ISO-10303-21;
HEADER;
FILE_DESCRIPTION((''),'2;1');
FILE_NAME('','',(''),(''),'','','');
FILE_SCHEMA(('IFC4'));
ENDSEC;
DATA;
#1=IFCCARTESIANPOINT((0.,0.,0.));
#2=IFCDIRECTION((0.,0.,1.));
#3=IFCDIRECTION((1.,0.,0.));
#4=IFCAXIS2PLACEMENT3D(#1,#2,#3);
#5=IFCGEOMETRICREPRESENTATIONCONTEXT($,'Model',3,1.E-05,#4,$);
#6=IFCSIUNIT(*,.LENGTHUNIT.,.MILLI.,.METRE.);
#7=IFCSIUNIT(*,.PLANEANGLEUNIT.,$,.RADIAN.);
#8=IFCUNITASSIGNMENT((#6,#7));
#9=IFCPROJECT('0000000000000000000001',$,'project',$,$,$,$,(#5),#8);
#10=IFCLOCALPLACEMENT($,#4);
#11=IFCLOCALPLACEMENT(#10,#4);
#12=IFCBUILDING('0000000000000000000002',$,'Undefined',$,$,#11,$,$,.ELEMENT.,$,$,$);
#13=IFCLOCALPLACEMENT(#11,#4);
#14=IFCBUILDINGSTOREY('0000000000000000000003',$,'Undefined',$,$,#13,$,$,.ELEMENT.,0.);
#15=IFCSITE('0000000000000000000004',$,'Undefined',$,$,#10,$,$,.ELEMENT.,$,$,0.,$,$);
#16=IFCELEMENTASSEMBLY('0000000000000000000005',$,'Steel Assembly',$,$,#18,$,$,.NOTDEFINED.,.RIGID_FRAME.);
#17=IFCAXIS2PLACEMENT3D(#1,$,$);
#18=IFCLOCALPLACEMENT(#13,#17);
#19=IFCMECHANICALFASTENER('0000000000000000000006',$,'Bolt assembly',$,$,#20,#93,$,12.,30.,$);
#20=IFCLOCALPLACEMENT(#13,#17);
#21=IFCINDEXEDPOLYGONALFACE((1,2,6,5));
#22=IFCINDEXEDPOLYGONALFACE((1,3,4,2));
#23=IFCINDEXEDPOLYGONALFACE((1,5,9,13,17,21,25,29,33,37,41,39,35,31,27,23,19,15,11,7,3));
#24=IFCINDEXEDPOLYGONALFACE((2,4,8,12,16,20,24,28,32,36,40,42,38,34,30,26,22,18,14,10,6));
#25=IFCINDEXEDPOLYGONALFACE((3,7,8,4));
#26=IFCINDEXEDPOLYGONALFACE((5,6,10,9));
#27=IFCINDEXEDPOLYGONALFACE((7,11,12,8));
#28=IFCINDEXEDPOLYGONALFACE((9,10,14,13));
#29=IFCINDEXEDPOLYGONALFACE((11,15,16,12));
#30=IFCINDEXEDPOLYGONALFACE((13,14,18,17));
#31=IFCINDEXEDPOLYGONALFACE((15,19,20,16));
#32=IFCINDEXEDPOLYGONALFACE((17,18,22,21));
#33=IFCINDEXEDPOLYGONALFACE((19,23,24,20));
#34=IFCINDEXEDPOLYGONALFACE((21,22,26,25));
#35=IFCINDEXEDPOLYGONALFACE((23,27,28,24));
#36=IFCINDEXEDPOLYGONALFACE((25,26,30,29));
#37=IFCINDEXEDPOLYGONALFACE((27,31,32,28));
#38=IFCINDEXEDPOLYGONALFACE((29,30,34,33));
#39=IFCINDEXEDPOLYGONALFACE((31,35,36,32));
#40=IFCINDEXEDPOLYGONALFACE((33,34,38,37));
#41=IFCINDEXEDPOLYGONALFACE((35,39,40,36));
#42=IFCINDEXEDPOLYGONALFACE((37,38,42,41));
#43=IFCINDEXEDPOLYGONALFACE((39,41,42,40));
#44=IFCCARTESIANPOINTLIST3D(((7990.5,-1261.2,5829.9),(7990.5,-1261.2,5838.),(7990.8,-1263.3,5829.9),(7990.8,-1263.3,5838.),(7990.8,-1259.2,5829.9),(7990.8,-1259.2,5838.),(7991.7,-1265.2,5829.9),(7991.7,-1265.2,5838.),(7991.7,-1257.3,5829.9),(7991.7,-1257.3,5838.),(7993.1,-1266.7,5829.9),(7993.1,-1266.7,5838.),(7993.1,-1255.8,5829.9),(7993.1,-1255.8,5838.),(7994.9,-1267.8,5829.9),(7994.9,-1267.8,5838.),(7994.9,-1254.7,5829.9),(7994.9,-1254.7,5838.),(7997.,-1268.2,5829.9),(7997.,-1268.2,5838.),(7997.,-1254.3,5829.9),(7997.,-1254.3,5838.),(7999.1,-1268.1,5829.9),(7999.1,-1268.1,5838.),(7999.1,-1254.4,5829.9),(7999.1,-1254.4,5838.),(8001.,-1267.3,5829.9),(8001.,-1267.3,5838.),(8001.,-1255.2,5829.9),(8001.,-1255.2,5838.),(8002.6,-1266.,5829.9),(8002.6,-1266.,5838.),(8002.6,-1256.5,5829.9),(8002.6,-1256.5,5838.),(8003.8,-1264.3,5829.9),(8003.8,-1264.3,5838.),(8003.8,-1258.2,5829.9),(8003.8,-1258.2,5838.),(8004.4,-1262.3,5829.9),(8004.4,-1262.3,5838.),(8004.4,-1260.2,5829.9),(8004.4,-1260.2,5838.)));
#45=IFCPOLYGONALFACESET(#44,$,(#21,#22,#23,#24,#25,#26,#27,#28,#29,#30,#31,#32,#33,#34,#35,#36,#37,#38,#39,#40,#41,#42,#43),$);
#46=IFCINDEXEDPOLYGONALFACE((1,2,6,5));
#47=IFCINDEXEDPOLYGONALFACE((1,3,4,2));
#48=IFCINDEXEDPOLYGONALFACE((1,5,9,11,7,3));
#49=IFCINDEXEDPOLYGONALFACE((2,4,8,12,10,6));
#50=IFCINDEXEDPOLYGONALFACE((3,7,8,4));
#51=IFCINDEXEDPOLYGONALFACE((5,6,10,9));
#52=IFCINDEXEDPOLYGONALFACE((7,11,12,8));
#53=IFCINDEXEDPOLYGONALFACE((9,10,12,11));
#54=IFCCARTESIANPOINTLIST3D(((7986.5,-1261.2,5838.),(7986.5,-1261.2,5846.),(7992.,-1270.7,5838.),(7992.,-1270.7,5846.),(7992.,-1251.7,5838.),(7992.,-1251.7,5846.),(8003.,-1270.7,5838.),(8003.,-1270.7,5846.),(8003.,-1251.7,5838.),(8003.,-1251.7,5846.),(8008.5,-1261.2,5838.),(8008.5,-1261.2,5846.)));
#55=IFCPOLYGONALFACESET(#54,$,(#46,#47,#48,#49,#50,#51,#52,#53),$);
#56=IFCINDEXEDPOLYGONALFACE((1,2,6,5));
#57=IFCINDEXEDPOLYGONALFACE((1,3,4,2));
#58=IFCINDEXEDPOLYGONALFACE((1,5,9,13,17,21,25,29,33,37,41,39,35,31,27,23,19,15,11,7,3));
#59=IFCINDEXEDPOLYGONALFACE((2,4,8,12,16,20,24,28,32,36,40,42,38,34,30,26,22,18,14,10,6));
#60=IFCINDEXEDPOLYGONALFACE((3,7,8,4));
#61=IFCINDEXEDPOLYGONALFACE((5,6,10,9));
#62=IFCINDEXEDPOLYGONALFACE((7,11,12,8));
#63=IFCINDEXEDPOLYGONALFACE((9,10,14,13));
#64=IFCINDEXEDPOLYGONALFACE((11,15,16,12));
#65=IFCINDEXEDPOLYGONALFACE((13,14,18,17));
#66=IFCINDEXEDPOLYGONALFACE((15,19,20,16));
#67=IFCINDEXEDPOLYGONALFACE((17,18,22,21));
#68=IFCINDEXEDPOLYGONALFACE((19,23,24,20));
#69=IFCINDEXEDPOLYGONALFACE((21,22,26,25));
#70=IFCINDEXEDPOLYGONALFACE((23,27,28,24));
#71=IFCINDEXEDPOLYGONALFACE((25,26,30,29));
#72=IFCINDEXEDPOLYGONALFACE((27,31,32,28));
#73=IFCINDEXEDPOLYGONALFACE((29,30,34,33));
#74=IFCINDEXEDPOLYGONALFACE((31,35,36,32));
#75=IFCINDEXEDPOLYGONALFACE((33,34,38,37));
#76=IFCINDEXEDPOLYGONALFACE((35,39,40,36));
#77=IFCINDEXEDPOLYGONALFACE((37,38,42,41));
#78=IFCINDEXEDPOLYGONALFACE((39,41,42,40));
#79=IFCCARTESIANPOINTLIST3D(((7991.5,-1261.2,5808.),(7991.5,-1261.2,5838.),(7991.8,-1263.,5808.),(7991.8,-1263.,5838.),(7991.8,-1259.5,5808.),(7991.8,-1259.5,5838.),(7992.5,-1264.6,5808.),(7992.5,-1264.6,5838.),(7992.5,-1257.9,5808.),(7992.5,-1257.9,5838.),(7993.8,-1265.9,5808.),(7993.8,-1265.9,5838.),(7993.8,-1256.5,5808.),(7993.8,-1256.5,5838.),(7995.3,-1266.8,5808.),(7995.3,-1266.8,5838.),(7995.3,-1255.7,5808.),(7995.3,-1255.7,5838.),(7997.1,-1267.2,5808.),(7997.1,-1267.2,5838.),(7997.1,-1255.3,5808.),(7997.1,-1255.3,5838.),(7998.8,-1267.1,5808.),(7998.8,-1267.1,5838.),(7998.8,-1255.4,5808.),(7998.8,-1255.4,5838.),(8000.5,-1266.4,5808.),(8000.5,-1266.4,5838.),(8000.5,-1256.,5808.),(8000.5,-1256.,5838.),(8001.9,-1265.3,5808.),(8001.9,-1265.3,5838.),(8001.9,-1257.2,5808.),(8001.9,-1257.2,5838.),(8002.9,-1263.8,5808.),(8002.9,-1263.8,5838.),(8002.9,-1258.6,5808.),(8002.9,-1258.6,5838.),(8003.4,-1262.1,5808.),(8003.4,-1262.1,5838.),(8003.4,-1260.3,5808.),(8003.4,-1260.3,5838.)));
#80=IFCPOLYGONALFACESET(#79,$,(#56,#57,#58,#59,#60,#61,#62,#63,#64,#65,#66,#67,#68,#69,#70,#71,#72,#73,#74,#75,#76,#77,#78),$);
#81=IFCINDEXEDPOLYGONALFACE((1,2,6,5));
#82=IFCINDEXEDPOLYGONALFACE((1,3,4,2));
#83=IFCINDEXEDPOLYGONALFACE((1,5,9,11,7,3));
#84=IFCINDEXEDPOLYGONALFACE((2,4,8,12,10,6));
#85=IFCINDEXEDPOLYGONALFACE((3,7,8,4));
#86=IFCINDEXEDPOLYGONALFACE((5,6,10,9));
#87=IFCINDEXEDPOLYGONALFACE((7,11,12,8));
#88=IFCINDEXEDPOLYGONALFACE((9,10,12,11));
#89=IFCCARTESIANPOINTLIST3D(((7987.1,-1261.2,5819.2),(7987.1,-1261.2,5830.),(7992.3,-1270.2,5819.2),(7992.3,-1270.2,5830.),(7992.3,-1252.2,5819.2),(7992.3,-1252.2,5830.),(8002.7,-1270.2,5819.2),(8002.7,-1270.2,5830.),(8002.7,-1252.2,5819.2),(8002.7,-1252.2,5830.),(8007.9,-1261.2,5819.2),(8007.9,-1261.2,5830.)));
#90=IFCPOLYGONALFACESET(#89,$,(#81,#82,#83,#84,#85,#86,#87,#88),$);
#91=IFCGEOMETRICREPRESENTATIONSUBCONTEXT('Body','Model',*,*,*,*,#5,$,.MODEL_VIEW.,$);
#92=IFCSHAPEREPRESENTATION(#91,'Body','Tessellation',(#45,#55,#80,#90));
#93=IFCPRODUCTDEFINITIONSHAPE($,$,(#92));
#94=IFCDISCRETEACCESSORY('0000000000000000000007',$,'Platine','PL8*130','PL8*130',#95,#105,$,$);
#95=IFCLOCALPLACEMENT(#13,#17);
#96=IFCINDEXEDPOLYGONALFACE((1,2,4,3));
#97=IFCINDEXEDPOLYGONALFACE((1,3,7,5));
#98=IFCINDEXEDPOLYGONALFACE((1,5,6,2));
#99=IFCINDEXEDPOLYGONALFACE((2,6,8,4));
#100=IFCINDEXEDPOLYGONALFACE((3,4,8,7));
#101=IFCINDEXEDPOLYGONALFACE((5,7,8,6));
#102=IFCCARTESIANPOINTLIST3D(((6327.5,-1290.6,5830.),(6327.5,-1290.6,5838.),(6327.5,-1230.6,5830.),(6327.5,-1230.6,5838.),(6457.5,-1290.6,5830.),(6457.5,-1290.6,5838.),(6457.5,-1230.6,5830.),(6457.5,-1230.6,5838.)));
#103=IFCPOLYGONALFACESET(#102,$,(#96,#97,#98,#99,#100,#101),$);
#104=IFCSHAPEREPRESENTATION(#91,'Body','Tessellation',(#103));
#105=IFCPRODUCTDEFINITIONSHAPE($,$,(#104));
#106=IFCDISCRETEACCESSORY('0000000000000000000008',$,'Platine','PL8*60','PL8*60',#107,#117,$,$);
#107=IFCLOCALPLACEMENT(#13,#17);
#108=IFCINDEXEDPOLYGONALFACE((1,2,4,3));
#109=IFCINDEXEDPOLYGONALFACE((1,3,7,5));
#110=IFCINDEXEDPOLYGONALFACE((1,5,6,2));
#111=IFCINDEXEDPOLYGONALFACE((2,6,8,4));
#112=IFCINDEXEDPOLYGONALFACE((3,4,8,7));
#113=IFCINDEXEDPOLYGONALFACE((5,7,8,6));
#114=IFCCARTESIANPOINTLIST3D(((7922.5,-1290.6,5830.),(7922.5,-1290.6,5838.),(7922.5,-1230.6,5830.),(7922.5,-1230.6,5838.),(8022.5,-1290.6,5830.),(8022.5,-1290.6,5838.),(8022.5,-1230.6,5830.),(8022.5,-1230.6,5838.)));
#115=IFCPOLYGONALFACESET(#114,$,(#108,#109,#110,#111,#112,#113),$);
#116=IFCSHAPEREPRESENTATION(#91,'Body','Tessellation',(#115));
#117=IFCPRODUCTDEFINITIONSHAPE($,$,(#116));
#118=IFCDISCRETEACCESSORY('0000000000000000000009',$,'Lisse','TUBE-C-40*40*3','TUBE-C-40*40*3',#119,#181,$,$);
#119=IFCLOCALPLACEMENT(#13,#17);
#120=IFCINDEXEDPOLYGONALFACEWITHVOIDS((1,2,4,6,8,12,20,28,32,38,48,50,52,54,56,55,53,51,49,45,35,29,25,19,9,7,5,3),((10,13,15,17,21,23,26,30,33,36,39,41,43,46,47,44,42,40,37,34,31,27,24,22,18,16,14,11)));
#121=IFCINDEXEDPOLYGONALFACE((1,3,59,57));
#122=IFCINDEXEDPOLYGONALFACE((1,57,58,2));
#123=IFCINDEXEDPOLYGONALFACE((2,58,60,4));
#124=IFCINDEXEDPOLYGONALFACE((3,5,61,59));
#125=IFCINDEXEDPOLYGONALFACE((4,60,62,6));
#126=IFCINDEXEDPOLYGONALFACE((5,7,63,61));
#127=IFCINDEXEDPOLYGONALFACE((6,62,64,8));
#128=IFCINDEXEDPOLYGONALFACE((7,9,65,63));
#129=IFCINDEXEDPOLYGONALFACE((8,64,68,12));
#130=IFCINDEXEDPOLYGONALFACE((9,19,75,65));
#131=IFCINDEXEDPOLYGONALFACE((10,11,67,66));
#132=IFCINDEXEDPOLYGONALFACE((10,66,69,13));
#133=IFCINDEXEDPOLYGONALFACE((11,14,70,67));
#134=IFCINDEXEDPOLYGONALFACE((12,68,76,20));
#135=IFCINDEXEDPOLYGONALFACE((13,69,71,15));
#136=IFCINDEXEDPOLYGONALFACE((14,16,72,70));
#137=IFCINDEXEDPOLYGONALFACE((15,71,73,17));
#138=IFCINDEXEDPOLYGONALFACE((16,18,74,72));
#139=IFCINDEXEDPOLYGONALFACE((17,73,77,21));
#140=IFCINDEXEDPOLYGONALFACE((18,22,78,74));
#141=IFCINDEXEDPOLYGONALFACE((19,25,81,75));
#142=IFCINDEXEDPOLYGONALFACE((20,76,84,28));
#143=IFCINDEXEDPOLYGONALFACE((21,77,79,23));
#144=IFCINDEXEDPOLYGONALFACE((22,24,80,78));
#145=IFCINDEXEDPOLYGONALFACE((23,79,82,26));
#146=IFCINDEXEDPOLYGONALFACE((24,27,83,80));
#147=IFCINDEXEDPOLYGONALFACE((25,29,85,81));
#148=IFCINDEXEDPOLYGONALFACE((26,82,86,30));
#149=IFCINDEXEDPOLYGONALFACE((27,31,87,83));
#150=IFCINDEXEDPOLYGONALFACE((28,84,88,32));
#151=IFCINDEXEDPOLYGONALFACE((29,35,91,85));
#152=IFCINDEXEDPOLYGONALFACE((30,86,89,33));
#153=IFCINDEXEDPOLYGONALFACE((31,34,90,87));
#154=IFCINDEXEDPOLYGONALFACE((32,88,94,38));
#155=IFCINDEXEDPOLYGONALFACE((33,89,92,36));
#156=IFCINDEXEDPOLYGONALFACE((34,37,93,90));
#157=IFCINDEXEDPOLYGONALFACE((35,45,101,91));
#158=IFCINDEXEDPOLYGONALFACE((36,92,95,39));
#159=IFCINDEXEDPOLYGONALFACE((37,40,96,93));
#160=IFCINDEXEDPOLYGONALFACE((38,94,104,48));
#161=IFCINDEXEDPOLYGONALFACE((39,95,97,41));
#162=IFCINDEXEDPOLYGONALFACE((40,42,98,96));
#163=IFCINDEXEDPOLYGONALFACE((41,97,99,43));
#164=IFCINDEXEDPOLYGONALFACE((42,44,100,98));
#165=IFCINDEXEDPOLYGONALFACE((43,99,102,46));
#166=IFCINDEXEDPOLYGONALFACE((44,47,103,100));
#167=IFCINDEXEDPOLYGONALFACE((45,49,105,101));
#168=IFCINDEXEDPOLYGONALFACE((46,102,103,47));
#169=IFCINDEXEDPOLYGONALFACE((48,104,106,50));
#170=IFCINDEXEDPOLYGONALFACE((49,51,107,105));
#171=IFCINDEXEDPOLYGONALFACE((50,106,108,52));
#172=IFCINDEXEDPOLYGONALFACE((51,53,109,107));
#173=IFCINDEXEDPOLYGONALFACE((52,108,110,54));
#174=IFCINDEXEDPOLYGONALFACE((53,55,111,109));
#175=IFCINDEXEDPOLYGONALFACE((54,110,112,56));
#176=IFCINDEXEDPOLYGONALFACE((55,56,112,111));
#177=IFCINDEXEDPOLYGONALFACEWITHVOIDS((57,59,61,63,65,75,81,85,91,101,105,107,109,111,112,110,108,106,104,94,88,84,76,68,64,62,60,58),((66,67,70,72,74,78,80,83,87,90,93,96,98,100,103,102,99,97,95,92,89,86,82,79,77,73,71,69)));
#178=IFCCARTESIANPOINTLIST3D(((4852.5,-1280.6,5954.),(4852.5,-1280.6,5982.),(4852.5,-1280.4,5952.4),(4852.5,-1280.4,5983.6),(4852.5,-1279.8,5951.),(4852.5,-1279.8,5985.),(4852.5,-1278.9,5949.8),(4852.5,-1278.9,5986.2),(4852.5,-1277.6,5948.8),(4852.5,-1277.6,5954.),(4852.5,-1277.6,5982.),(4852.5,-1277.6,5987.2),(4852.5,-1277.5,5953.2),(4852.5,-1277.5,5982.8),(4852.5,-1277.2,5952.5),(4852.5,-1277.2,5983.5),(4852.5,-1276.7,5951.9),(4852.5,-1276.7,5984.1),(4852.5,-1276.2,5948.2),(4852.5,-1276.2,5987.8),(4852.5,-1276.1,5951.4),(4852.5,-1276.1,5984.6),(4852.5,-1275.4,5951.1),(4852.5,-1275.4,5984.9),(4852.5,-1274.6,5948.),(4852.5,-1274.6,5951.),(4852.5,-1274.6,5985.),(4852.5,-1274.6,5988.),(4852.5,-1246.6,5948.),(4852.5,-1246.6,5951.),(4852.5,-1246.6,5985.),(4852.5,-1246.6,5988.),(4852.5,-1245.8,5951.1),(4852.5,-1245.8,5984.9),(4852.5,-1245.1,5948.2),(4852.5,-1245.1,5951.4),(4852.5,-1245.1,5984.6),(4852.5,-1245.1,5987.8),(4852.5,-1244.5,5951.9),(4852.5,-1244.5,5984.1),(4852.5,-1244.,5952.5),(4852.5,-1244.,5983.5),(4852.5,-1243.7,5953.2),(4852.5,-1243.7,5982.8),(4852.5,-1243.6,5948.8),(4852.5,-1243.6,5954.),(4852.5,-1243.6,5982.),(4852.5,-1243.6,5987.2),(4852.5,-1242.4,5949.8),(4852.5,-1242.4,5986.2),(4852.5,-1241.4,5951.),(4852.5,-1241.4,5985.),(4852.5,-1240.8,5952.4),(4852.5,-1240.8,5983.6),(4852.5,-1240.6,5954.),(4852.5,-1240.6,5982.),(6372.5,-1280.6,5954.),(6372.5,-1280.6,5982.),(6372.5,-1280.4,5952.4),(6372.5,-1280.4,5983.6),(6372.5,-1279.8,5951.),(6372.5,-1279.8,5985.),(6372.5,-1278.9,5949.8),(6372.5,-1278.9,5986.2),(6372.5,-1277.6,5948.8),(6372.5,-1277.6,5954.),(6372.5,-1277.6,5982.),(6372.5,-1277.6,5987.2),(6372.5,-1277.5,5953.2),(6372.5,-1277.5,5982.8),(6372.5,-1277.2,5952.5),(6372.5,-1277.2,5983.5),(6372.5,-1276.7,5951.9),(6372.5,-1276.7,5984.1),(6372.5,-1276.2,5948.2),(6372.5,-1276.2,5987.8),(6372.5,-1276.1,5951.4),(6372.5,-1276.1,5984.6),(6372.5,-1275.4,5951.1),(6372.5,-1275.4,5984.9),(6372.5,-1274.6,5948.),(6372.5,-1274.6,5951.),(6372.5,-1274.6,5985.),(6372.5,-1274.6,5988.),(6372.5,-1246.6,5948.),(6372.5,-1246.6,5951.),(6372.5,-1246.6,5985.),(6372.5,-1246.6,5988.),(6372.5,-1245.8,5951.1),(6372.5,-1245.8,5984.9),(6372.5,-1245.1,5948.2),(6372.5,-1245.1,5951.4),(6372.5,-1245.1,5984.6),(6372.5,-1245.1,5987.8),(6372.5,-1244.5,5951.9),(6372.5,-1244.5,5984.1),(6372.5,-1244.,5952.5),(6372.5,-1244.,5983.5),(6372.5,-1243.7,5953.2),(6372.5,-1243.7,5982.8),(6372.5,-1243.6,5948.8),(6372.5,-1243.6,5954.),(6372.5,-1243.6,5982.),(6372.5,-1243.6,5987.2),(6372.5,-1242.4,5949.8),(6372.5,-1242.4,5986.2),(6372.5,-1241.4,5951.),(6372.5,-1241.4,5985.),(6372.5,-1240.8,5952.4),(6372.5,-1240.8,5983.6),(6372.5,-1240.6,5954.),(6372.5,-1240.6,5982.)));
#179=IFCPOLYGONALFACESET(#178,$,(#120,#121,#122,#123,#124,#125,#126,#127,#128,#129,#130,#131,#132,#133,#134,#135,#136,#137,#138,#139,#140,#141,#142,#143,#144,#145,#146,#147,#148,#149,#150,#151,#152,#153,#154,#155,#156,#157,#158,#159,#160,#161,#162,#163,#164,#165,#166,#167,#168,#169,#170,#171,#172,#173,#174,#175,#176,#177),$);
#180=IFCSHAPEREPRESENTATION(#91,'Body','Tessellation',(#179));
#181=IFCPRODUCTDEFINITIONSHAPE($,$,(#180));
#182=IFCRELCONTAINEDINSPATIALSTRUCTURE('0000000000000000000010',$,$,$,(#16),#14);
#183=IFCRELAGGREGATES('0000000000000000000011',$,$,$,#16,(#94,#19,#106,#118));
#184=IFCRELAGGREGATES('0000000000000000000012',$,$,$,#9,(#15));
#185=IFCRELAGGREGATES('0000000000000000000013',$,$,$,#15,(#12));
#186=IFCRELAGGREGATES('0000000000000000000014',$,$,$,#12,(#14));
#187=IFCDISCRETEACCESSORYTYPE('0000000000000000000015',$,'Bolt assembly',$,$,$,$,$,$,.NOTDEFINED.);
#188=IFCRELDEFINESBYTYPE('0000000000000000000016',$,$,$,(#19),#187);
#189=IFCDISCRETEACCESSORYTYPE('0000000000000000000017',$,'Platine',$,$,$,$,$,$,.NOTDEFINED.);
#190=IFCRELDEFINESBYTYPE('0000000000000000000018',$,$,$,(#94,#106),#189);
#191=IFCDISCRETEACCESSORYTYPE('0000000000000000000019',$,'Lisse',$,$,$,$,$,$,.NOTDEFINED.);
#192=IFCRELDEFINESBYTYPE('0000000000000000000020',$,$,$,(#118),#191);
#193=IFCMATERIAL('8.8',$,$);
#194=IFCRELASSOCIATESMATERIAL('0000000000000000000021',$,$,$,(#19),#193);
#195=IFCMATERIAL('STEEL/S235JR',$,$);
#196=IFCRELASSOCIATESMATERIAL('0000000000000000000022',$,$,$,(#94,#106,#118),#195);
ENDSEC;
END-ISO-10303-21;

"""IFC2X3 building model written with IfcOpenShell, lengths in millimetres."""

from ifc_helpers import new_model, si_unit, frame, origin_with_axes, origin_2d_with_axis, place, context, subcontext, project, spatial, polyline, hollow_rectangle, circle, outline, extrude, source, transform, mapped, material, type_object, element, aggregate, save


model = new_model("IFC2X3")

# Units and contexts
model_context = context("Model", 3, precision=1e-05, world=origin_with_axes())
body_context = subcontext(model_context, "Body", "Model", "MODEL_VIEW")
ifc_project = project(units=[si_unit("LENGTHUNIT", "METRE", prefix="MILLI"), si_unit("PLANEANGLEUNIT", "RADIAN")], contexts=[model_context])

# Site, building, storey
site_placement = place(None, origin_with_axes())
site = spatial("IfcSite", under=ifc_project, at=site_placement, Name="Undefined", CompositionType="ELEMENT", RefElevation=0.0)
building_placement = place(site_placement, origin_with_axes())
building = spatial("IfcBuilding", under=site, at=building_placement, Name="Undefined", CompositionType="ELEMENT")
storey_placement = place(building_placement, origin_with_axes())
storey = spatial("IfcBuildingStorey", under=building, at=storey_placement, Name="Undefined", CompositionType="ELEMENT", Elevation=0.0)

# Element assembly
assembly_1_placement = place(storey_placement, origin_with_axes())
assembly_1 = element("IfcElementAssembly", 1, at=assembly_1_placement, inside=storey, Name="Steel Assembly", AssemblyPlace="NOTDEFINED", PredefinedType="RIGID_FRAME")
ifc_material_1 = material(Name="STEEL/S235JR")

# Mechanical fastener
ifc_material_2 = material(Name="8.8")
discrete_accessory_type_1 = type_object("IfcDiscreteAccessoryType", Name="Bolt assembly")
shared_shape_1 = source(origin_with_axes(), body_context, "Body", "SweptSolid", [
    extrude(circle(Radius=7.0, at=origin_2d_with_axis()), frame((0.0, 0.0, 0.0), z_axis=(0.0, 1.0, 0.0), x_axis=(1.0, 0.0, 0.0)), (0.0, 0.0, 1.0), 8.1),
    extrude(outline(polyline([(11.0, 0.0), (5.5, 9.5), (-5.5, 9.5), (-11.0, 0.0), (-5.5, -9.5), (5.5, -9.5), (11.0, 0.0)])), frame((0.0, -8.0, 0.0), z_axis=(0.0, 1.0, 0.0), x_axis=(1.0, 0.0, 0.0)), (0.0, 0.0, 1.0), 8.0),
    extrude(circle(Radius=6.0, at=origin_2d_with_axis()), frame((0.0, 0.0, 0.0), z_axis=(0.0, 1.0, 0.0), x_axis=(1.0, 0.0, 0.0)), (0.0, 0.0, 1.0), 30.0),
    extrude(outline(polyline([(10.4, 0.0), (5.2, 9.0), (-5.2, 9.0), (-10.4, 0.0), (-5.2, -9.0), (5.2, -9.0), (10.4, 0.0)])), frame((0.0, 8.0, 0.0), z_axis=(0.0, 1.0, 0.0), x_axis=(1.0, 0.0, 0.0)), (0.0, 0.0, 1.0), 10.8),
])
mechanical_fastener_1_placement = place(assembly_1_placement, frame((7997.5, -1261.2, 5838.0), z_axis=(0.0, -1.0, 0.0), x_axis=(-1.0, 0.0, 0.0)))
mechanical_fastener_1 = element("IfcMechanicalFastener", 2, at=mechanical_fastener_1_placement, type_object=discrete_accessory_type_1, material=ifc_material_2, Name="Bolt assembly", NominalDiameter=12.0, NominalLength=30.0, context=body_context, shape_type="MappedRepresentation", body=[
    mapped(shared_shape_1, transform((0.0, 0.0, 0.0))),
])

# Discrete accessories
discrete_accessory_type_2 = type_object("IfcDiscreteAccessoryType", Name="Platine")
discrete_accessory_1_placement = place(assembly_1_placement, frame((6392.5, -1290.6, 5834.0), z_axis=(0.0, 0.0, 1.0), x_axis=(0.0, 1.0, 0.0)))
discrete_accessory_1 = element("IfcDiscreteAccessory", 3, at=discrete_accessory_1_placement, type_object=discrete_accessory_type_2, material=ifc_material_1, Name="Platine", Description="PL8*130", ObjectType="PL8*130", context=body_context, shape_type="SweptSolid", body=[
    extrude(outline(polyline([(60.0, 65.0), (60.0, -65.0), (0.0, -65.0), (0.0, 65.0), (60.0, 65.0)])), frame((0.0, 0.0, -4.0), z_axis=(0.0, 0.0, 1.0), x_axis=(1.0, 0.0, 0.0)), (0.0, 0.0, 1.0), 8.0),
])
discrete_accessory_2_placement = place(assembly_1_placement, frame((7922.5, -1230.6, 5834.0), z_axis=(0.0, 0.0, -1.0), x_axis=(1.0, 0.0, 0.0)))
discrete_accessory_2 = element("IfcDiscreteAccessory", 4, at=discrete_accessory_2_placement, type_object=discrete_accessory_type_2, material=ifc_material_1, Name="Platine", Description="PL8*60", ObjectType="PL8*60", context=body_context, shape_type="SweptSolid", body=[
    extrude(outline(polyline([(0.0, 0.0), (100.0, 0.0), (100.0, 60.0), (0.0, 60.0), (0.0, 0.0)])), frame((0.0, 0.0, -4.0), z_axis=(0.0, 0.0, 1.0), x_axis=(1.0, 0.0, 0.0)), (0.0, 0.0, 1.0), 8.0),
])

# Discrete accessory
discrete_accessory_type_3 = type_object("IfcDiscreteAccessoryType", Name="Lisse")
discrete_accessory_3_placement = place(assembly_1_placement, frame((6372.5, -1260.6, 5968.0), z_axis=(0.0, 1.0, 0.0), x_axis=(-1.0, 0.0, 0.0)))
discrete_accessory_3 = element("IfcDiscreteAccessory", 5, at=discrete_accessory_3_placement, type_object=discrete_accessory_type_3, material=ifc_material_1, Name="Lisse", Description="TUBE-C-40*40*3", ObjectType="TUBE-C-40*40*3", context=body_context, shape_type="SweptSolid", body=[
    extrude(hollow_rectangle(XDim=40.0, YDim=40.0, WallThickness=3.0, InnerFilletRadius=3.0, OuterFilletRadius=6.0, at=origin_2d_with_axis()), frame((1520.0, 0.0, 0.0), z_axis=(-1.0, 0.0, 0.0), x_axis=(0.0, -1.0, 0.0)), (0.0, 0.0, 1.0), 1520.0),
])
aggregate(assembly_1, [discrete_accessory_1, mechanical_fastener_1, discrete_accessory_2, discrete_accessory_3])

save(model, "model.ifc")
